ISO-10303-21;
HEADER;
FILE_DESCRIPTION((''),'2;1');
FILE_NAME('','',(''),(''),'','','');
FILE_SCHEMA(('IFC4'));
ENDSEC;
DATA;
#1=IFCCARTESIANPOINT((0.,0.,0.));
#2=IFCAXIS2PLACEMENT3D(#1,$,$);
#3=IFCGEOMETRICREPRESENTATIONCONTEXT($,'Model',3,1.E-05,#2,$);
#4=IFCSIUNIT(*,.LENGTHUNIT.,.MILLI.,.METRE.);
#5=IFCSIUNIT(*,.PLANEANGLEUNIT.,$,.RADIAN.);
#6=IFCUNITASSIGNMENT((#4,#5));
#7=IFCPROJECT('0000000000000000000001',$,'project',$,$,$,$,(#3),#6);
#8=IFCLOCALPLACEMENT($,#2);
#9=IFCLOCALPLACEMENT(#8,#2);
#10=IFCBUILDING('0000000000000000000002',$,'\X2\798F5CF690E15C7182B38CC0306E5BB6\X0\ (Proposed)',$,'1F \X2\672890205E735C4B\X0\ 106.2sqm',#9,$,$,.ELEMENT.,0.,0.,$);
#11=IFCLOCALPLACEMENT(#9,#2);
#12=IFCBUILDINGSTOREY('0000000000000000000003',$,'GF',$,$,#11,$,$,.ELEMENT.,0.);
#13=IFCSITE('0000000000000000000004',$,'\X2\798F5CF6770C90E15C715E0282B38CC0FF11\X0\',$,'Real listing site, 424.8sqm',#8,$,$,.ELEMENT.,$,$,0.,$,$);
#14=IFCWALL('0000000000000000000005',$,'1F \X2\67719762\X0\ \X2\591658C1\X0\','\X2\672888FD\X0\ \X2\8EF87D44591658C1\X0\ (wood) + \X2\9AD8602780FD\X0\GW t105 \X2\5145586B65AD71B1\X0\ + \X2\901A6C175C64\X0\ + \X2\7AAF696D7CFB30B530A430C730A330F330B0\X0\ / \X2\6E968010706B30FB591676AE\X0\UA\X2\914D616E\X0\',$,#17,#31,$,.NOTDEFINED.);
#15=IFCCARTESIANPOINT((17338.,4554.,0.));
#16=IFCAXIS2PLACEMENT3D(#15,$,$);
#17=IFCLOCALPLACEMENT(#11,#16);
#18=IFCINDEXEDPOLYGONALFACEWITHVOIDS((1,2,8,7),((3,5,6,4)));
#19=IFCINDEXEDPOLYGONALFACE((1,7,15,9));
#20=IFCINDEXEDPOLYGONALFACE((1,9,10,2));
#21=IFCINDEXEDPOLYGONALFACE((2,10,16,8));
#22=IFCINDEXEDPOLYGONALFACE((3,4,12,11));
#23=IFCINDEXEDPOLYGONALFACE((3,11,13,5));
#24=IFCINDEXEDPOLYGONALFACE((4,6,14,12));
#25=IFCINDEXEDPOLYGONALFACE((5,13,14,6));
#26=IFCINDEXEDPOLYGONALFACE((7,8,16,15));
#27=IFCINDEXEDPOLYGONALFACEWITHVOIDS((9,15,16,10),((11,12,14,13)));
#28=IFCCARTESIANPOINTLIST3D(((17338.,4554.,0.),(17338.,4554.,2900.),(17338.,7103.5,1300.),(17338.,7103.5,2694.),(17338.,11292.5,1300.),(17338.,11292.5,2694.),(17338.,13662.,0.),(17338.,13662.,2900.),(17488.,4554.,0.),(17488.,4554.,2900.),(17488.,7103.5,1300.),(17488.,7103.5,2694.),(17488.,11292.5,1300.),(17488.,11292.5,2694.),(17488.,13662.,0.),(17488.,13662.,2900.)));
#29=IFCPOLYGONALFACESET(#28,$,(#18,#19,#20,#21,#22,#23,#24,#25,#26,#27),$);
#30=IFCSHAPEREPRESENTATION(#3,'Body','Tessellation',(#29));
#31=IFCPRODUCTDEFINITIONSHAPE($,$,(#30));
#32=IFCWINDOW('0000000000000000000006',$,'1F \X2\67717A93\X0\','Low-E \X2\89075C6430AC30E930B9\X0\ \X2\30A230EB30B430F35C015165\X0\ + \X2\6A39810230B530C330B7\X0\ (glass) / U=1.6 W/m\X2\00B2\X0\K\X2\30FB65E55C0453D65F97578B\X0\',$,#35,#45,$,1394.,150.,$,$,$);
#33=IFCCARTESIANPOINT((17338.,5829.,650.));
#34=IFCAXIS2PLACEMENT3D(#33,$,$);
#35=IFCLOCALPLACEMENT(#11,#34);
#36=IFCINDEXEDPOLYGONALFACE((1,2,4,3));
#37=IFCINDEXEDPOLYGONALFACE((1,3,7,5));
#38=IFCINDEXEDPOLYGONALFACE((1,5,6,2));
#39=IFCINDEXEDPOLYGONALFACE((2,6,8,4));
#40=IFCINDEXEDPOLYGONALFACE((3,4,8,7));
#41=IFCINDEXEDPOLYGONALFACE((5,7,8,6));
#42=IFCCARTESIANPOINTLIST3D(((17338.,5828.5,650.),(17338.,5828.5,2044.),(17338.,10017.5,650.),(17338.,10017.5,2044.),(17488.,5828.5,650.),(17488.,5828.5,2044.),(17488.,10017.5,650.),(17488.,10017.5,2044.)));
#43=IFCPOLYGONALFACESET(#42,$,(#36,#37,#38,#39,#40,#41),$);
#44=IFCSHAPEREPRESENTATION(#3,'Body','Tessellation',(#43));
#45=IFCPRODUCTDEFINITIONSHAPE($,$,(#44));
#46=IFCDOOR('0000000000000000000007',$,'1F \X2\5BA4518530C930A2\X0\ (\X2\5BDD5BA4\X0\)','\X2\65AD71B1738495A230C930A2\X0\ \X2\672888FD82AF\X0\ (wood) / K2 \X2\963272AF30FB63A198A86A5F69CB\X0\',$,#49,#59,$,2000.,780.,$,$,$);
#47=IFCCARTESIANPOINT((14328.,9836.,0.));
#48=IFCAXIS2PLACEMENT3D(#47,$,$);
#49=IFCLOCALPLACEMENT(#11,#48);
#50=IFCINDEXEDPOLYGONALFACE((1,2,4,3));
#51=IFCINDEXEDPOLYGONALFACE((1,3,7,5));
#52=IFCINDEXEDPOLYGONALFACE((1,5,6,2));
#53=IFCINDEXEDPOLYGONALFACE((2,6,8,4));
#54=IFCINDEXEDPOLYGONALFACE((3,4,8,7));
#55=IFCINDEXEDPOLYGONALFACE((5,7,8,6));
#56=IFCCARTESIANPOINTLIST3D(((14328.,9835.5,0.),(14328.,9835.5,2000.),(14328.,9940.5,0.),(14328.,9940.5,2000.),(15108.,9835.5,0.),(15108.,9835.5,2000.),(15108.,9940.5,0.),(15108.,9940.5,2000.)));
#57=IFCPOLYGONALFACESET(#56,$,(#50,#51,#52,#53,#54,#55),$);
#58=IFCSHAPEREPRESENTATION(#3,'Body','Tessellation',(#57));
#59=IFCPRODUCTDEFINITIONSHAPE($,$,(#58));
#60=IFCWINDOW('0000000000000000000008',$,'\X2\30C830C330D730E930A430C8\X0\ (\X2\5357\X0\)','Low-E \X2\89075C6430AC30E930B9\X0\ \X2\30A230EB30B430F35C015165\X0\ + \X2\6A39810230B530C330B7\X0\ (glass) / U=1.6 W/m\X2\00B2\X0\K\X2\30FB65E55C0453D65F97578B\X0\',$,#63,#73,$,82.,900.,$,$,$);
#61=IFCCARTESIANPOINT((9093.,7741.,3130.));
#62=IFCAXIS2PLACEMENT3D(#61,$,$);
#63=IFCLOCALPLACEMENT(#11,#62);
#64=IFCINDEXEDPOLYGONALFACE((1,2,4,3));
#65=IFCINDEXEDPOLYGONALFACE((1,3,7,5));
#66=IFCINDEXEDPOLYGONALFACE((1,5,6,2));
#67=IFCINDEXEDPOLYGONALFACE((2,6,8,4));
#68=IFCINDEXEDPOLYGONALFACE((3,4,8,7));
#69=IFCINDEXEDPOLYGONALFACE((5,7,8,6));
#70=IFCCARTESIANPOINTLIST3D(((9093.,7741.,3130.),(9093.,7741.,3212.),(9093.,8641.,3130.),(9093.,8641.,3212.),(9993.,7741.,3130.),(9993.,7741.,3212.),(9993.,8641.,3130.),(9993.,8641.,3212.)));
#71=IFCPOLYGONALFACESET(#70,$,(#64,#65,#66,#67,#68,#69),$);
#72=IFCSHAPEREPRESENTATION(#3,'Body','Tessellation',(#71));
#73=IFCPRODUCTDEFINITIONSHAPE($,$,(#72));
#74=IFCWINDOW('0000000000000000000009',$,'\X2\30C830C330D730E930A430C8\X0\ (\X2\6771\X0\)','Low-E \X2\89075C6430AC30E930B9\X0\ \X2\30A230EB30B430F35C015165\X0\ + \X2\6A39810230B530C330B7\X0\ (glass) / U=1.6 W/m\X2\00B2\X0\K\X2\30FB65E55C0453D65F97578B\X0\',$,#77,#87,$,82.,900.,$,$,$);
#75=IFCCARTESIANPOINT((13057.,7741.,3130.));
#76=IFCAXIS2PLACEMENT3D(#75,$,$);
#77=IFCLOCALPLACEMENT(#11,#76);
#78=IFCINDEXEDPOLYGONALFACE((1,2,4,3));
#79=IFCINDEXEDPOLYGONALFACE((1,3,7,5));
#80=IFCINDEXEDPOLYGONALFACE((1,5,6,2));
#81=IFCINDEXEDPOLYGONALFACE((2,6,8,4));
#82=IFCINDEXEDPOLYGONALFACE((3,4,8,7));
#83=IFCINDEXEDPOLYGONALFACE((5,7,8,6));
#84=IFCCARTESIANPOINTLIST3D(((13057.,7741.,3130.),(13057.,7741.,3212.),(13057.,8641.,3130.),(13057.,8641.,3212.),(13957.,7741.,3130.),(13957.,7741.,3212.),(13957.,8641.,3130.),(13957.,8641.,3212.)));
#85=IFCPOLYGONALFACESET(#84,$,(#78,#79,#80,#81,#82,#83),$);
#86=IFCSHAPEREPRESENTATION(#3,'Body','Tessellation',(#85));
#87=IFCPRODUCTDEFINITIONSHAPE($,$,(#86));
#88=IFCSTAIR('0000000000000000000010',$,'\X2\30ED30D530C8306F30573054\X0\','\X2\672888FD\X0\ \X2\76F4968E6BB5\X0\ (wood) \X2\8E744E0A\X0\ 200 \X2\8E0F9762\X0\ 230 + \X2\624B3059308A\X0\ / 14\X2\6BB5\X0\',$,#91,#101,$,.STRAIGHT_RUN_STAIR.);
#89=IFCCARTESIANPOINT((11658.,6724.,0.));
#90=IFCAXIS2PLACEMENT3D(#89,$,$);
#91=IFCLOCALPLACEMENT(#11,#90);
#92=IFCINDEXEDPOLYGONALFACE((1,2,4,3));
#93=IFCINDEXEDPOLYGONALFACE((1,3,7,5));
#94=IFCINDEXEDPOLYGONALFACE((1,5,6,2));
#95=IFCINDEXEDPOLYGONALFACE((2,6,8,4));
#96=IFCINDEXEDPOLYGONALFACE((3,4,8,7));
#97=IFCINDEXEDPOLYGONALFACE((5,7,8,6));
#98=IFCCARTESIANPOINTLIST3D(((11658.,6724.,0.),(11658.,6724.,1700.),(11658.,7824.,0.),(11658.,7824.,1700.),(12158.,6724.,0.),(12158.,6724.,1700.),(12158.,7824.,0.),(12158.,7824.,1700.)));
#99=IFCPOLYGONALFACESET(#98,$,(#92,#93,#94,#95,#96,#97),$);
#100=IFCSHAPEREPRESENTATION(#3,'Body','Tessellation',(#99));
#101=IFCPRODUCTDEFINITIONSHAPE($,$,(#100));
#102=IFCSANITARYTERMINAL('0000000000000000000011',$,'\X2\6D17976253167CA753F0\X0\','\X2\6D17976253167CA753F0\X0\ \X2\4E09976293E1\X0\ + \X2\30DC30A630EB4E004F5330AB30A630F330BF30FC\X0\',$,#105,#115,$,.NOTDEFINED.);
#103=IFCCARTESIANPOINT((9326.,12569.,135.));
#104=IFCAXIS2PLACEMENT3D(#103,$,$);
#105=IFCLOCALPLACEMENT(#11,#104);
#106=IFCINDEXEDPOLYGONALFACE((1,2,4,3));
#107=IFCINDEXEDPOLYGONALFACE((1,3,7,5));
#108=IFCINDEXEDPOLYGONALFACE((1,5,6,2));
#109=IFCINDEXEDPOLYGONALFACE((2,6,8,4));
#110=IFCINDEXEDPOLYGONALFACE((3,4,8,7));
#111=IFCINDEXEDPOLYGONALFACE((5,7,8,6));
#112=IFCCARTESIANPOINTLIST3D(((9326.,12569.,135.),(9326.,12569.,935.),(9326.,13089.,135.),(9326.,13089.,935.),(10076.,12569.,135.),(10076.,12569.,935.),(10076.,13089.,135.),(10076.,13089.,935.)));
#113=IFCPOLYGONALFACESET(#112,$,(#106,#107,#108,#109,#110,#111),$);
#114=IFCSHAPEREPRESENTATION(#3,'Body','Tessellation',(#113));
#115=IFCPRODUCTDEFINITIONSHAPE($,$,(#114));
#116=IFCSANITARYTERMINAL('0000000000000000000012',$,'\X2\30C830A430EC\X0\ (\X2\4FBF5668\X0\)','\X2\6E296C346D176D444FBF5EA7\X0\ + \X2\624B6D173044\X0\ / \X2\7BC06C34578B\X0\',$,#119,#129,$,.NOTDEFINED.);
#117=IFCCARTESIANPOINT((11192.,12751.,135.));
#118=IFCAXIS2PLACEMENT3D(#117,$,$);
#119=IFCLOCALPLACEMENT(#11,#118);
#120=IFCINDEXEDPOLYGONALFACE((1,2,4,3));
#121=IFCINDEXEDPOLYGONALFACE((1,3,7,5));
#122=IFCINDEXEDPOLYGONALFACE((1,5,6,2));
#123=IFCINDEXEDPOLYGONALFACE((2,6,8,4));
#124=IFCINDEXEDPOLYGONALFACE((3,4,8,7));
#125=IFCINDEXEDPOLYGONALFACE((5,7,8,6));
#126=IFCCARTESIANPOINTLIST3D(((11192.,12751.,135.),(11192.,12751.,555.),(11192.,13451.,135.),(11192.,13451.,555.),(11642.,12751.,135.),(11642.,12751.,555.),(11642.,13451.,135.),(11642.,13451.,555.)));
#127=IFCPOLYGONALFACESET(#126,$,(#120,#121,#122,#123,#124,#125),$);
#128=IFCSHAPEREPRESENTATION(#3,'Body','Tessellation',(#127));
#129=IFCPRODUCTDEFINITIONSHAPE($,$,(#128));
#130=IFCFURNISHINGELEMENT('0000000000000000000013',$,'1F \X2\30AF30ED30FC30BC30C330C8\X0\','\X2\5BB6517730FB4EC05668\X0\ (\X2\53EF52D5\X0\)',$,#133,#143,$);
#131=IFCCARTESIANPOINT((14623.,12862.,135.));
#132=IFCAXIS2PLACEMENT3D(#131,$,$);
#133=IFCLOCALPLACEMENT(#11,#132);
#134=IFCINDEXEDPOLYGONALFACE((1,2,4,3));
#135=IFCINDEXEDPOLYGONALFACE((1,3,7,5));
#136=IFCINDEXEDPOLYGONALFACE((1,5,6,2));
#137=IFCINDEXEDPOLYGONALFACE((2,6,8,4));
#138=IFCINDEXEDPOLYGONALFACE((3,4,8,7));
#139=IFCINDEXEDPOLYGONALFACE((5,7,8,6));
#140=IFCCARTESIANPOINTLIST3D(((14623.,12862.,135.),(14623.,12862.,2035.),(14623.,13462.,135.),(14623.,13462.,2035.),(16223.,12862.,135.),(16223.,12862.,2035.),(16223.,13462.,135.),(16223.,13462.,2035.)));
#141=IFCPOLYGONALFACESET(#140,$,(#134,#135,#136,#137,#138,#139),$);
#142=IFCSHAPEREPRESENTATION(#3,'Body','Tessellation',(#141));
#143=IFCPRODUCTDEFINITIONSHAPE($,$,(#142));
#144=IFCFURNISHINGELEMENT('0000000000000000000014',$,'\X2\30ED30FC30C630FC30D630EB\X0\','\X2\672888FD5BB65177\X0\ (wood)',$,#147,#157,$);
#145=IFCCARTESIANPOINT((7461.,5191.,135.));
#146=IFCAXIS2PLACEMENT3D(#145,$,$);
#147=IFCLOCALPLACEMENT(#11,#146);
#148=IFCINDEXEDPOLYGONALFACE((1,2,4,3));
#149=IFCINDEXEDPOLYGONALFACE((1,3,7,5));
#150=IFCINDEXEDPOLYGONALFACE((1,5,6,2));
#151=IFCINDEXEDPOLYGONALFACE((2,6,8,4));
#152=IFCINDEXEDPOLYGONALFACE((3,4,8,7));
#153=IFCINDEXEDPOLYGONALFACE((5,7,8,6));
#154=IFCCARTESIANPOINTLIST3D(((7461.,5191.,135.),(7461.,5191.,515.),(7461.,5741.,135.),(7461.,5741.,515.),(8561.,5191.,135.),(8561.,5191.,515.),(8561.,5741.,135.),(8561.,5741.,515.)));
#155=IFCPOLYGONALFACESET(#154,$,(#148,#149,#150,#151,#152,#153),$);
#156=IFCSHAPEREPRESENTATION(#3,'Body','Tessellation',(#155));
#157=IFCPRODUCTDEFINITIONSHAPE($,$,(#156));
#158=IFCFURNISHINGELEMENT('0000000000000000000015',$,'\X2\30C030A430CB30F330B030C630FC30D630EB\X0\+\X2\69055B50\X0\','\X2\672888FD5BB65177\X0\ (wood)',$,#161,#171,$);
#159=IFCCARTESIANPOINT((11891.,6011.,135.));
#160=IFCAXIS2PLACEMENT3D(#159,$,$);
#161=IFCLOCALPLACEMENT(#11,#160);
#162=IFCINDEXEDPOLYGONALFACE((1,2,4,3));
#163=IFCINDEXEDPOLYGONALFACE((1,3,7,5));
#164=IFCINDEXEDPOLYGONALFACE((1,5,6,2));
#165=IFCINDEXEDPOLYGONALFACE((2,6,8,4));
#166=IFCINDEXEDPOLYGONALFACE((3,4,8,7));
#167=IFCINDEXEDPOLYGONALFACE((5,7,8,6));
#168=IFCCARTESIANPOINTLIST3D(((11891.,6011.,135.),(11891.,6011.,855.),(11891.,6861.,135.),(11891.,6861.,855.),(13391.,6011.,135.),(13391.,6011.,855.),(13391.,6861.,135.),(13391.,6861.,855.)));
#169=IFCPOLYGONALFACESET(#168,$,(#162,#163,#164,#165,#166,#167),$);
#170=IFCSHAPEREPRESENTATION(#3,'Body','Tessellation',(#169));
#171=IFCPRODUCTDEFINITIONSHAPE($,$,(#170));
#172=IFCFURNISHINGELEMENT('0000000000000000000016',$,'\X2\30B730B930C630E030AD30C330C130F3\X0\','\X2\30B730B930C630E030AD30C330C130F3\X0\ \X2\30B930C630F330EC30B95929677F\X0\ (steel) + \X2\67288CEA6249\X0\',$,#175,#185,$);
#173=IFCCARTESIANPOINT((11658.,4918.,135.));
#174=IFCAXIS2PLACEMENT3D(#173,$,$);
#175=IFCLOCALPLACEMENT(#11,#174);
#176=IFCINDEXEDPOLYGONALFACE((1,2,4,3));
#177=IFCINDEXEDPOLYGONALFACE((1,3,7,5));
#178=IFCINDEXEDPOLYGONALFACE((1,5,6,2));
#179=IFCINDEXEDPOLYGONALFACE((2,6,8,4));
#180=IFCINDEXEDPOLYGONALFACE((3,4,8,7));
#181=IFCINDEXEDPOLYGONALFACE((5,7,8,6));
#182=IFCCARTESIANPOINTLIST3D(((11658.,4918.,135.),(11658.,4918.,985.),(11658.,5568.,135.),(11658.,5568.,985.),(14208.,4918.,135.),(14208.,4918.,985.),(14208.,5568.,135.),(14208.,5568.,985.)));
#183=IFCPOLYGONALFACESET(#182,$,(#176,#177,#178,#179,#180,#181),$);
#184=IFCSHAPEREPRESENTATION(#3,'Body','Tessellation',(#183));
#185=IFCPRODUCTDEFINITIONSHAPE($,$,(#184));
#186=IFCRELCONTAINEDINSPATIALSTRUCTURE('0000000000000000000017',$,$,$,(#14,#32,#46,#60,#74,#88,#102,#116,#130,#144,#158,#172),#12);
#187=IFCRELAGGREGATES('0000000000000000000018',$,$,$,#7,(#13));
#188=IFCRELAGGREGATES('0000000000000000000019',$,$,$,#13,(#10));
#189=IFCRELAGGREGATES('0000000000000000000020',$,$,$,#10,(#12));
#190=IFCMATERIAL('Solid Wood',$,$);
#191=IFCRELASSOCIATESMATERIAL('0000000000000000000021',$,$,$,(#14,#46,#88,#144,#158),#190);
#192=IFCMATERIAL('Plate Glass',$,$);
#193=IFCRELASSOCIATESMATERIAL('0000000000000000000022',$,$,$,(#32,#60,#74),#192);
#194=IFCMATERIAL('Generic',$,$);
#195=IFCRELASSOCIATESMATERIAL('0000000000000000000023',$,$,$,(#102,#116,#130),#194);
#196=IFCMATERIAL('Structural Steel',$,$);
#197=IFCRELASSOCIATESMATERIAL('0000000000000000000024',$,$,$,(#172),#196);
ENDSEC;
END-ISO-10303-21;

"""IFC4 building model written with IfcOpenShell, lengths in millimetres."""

from ifc_helpers import new_model, si_unit, frame, frame_2d, origin, place, context, project, spatial, rectangle, extrude, material, element, fill, save


model = new_model("IFC4")

# Units and contexts
model_context = context("Model", 3, precision=1e-05, world=origin())
ifc_project = project(units=[si_unit("LENGTHUNIT", "METRE", prefix="MILLI"), si_unit("PLANEANGLEUNIT", "RADIAN")], contexts=[model_context])

# Site, building, storey
site_placement = place(None, origin())
site = spatial("IfcSite", under=ifc_project, at=site_placement, Name="福島県郡山市芳賀１", ObjectType="Real listing site, 424.8sqm", CompositionType="ELEMENT", RefElevation=0.0)
building_placement = place(site_placement, origin())
building = spatial("IfcBuilding", under=site, at=building_placement, Name="福島郡山芳賀の家 (Proposed)", ObjectType="1F 木造平屋 106.2sqm", CompositionType="ELEMENT", ElevationOfRefHeight=0.0, ElevationOfTerrain=0.0)
storey_placement = place(building_placement, origin())
storey = spatial("IfcBuildingStorey", under=building, at=storey_placement, Name="GF", CompositionType="ELEMENT", Elevation=0.0)

# Wall, opening, window
ifc_material_1 = material(Name="Solid Wood")
wall_1_placement = place(storey_placement, frame((17338.0, 4554.0, 0.0)))
wall_1 = element("IfcWall", 1, at=wall_1_placement, inside=storey, material=ifc_material_1, Name="1F 東面 外壁", Description="木製 軸組外壁 (wood) + 高性能GW t105 充填断熱 + 通気層 + 窯業系サイディング / 準耐火・外皮UA配慮", PredefinedType="NOTDEFINED", context=model_context, shape_type="SweptSolid", body=[
    extrude(rectangle(XDim=150.0, YDim=9108.0, at=frame_2d((75.0, 4554.0))), frame((17338.0, 4554.0, 0.0)), (0.0, 0.0, 1.0), 2900.0),
])
opening_placement = place(storey_placement, frame((17338.0, 5829.0, 650.0)))
opening = element("IfcOpeningElement", 2, at=opening_placement, cuts=wall_1, PredefinedType="NOTDEFINED", context=model_context, shape_type="SweptSolid", body=[
    extrude(rectangle(XDim=150.0, YDim=4189.0, at=frame_2d((75.0, 2094.0))), frame((17338.0, 5829.0, 650.0)), (0.0, 0.0, 1.0), 1394.0),
])
ifc_material_2 = material(Name="Plate Glass")
window_1_placement = place(storey_placement, frame((17338.0, 5829.0, 650.0)))
window_1 = element("IfcWindow", 3, at=window_1_placement, inside=storey, material=ifc_material_2, Name="1F 東窓", Description="Low-E 複層ガラス アルゴン封入 + 樹脂サッシ (glass) / U=1.6 W/m²K・日射取得型", OverallHeight=1394.0, OverallWidth=150.0, context=model_context, shape_type="SweptSolid", body=[
    extrude(rectangle(XDim=150.0, YDim=4189.0, at=frame_2d((75.0, 2094.0))), frame((17338.0, 5829.0, 650.0)), (0.0, 0.0, 1.0), 1394.0),
])
fill(opening, window_1)

# Door
door_placement = place(storey_placement, frame((14328.0, 9836.0, 0.0)))
element("IfcDoor", 4, at=door_placement, inside=storey, material=ifc_material_1, Name="1F 室内ドア (寝室)", Description="断熱玄関ドア 木製芯 (wood) / K2 防犯・採風機構", OverallHeight=2000.0, OverallWidth=780.0, context=model_context, shape_type="SweptSolid", body=[
    extrude(rectangle(XDim=780.0, YDim=105.0, at=frame_2d((390.0, 52.0))), frame((14328.0, 9836.0, 0.0)), (0.0, 0.0, 1.0), 2000.0),
])

# Windows
window_2_placement = place(storey_placement, frame((9093.0, 7741.0, 3130.0)))
element("IfcWindow", 5, at=window_2_placement, inside=storey, material=ifc_material_2, Name="トップライト (南)", Description="Low-E 複層ガラス アルゴン封入 + 樹脂サッシ (glass) / U=1.6 W/m²K・日射取得型", OverallHeight=82.0, OverallWidth=900.0, context=model_context, shape_type="SweptSolid", body=[
    extrude(rectangle(XDim=900.0, YDim=900.0, at=frame_2d((450.0, 450.0))), frame((9093.0, 7741.0, 3130.0)), (0.0, 0.0, 1.0), 82.0),
])
window_3_placement = place(storey_placement, frame((13057.0, 7741.0, 3130.0)))
element("IfcWindow", 6, at=window_3_placement, inside=storey, material=ifc_material_2, Name="トップライト (東)", Description="Low-E 複層ガラス アルゴン封入 + 樹脂サッシ (glass) / U=1.6 W/m²K・日射取得型", OverallHeight=82.0, OverallWidth=900.0, context=model_context, shape_type="SweptSolid", body=[
    extrude(rectangle(XDim=900.0, YDim=900.0, at=frame_2d((450.0, 450.0))), frame((13057.0, 7741.0, 3130.0)), (0.0, 0.0, 1.0), 82.0),
])

# Stair
stair_placement = place(storey_placement, frame((11658.0, 6724.0, 0.0)))
element("IfcStair", 7, at=stair_placement, inside=storey, material=ifc_material_1, Name="ロフトはしご", Description="木製 直階段 (wood) 蹴上 200 踏面 230 + 手すり / 14段", PredefinedType="STRAIGHT_RUN_STAIR", context=model_context, shape_type="SweptSolid", body=[
    extrude(rectangle(XDim=500.0, YDim=1100.0, at=frame_2d((250.0, 550.0))), frame((11658.0, 6724.0, 0.0)), (0.0, 0.0, 1.0), 1700.0),
])

# Sanitary terminals
ifc_material_3 = material(Name="Generic")
sanitary_terminal_1_placement = place(storey_placement, frame((9326.0, 12569.0, 135.0)))
element("IfcSanitaryTerminal", 8, at=sanitary_terminal_1_placement, inside=storey, material=ifc_material_3, Name="洗面化粧台", Description="洗面化粧台 三面鏡 + ボウル一体カウンター", PredefinedType="NOTDEFINED", context=model_context, shape_type="SweptSolid", body=[
    extrude(rectangle(XDim=750.0, YDim=520.0, at=frame_2d((375.0, 260.0))), frame((9326.0, 12569.0, 135.0)), (0.0, 0.0, 1.0), 800.0),
])
sanitary_terminal_2_placement = place(storey_placement, frame((11192.0, 12751.0, 135.0)))
element("IfcSanitaryTerminal", 9, at=sanitary_terminal_2_placement, inside=storey, material=ifc_material_3, Name="トイレ (便器)", Description="温水洗浄便座 + 手洗い / 節水型", PredefinedType="NOTDEFINED", context=model_context, shape_type="SweptSolid", body=[
    extrude(rectangle(XDim=450.0, YDim=700.0, at=frame_2d((225.0, 350.0))), frame((11192.0, 12751.0, 135.0)), (0.0, 0.0, 1.0), 420.0),
])

# Furnishing elements
furnishing_1_placement = place(storey_placement, frame((14623.0, 12862.0, 135.0)))
element("IfcFurnishingElement", 10, at=furnishing_1_placement, inside=storey, material=ifc_material_3, Name="1F クローゼット", Description="家具・什器 (可動)", context=model_context, shape_type="SweptSolid", body=[
    extrude(rectangle(XDim=1600.0, YDim=600.0, at=frame_2d((800.0, 300.0))), frame((14623.0, 12862.0, 135.0)), (0.0, 0.0, 1.0), 1900.0),
])
furnishing_2_placement = place(storey_placement, frame((7461.0, 5191.0, 135.0)))
element("IfcFurnishingElement", 11, at=furnishing_2_placement, inside=storey, material=ifc_material_1, Name="ローテーブル", Description="木製家具 (wood)", context=model_context, shape_type="SweptSolid", body=[
    extrude(rectangle(XDim=1100.0, YDim=550.0, at=frame_2d((550.0, 275.0))), frame((7461.0, 5191.0, 135.0)), (0.0, 0.0, 1.0), 380.0),
])
furnishing_3_placement = place(storey_placement, frame((11891.0, 6011.0, 135.0)))
element("IfcFurnishingElement", 12, at=furnishing_3_placement, inside=storey, material=ifc_material_1, Name="ダイニングテーブル+椅子", Description="木製家具 (wood)", context=model_context, shape_type="SweptSolid", body=[
    extrude(rectangle(XDim=1500.0, YDim=850.0, at=frame_2d((750.0, 425.0))), frame((11891.0, 6011.0, 135.0)), (0.0, 0.0, 1.0), 720.0),
])
ifc_material_4 = material(Name="Structural Steel")
furnishing_4_placement = place(storey_placement, frame((11658.0, 4918.0, 135.0)))
element("IfcFurnishingElement", 13, at=furnishing_4_placement, inside=storey, material=ifc_material_4, Name="システムキッチン", Description="システムキッチン ステンレス天板 (steel) + 木質扉", context=model_context, shape_type="SweptSolid", body=[
    extrude(rectangle(XDim=2550.0, YDim=650.0, at=frame_2d((1275.0, 325.0))), frame((11658.0, 4918.0, 135.0)), (0.0, 0.0, 1.0), 850.0),
])

save(model, "model.ifc")
